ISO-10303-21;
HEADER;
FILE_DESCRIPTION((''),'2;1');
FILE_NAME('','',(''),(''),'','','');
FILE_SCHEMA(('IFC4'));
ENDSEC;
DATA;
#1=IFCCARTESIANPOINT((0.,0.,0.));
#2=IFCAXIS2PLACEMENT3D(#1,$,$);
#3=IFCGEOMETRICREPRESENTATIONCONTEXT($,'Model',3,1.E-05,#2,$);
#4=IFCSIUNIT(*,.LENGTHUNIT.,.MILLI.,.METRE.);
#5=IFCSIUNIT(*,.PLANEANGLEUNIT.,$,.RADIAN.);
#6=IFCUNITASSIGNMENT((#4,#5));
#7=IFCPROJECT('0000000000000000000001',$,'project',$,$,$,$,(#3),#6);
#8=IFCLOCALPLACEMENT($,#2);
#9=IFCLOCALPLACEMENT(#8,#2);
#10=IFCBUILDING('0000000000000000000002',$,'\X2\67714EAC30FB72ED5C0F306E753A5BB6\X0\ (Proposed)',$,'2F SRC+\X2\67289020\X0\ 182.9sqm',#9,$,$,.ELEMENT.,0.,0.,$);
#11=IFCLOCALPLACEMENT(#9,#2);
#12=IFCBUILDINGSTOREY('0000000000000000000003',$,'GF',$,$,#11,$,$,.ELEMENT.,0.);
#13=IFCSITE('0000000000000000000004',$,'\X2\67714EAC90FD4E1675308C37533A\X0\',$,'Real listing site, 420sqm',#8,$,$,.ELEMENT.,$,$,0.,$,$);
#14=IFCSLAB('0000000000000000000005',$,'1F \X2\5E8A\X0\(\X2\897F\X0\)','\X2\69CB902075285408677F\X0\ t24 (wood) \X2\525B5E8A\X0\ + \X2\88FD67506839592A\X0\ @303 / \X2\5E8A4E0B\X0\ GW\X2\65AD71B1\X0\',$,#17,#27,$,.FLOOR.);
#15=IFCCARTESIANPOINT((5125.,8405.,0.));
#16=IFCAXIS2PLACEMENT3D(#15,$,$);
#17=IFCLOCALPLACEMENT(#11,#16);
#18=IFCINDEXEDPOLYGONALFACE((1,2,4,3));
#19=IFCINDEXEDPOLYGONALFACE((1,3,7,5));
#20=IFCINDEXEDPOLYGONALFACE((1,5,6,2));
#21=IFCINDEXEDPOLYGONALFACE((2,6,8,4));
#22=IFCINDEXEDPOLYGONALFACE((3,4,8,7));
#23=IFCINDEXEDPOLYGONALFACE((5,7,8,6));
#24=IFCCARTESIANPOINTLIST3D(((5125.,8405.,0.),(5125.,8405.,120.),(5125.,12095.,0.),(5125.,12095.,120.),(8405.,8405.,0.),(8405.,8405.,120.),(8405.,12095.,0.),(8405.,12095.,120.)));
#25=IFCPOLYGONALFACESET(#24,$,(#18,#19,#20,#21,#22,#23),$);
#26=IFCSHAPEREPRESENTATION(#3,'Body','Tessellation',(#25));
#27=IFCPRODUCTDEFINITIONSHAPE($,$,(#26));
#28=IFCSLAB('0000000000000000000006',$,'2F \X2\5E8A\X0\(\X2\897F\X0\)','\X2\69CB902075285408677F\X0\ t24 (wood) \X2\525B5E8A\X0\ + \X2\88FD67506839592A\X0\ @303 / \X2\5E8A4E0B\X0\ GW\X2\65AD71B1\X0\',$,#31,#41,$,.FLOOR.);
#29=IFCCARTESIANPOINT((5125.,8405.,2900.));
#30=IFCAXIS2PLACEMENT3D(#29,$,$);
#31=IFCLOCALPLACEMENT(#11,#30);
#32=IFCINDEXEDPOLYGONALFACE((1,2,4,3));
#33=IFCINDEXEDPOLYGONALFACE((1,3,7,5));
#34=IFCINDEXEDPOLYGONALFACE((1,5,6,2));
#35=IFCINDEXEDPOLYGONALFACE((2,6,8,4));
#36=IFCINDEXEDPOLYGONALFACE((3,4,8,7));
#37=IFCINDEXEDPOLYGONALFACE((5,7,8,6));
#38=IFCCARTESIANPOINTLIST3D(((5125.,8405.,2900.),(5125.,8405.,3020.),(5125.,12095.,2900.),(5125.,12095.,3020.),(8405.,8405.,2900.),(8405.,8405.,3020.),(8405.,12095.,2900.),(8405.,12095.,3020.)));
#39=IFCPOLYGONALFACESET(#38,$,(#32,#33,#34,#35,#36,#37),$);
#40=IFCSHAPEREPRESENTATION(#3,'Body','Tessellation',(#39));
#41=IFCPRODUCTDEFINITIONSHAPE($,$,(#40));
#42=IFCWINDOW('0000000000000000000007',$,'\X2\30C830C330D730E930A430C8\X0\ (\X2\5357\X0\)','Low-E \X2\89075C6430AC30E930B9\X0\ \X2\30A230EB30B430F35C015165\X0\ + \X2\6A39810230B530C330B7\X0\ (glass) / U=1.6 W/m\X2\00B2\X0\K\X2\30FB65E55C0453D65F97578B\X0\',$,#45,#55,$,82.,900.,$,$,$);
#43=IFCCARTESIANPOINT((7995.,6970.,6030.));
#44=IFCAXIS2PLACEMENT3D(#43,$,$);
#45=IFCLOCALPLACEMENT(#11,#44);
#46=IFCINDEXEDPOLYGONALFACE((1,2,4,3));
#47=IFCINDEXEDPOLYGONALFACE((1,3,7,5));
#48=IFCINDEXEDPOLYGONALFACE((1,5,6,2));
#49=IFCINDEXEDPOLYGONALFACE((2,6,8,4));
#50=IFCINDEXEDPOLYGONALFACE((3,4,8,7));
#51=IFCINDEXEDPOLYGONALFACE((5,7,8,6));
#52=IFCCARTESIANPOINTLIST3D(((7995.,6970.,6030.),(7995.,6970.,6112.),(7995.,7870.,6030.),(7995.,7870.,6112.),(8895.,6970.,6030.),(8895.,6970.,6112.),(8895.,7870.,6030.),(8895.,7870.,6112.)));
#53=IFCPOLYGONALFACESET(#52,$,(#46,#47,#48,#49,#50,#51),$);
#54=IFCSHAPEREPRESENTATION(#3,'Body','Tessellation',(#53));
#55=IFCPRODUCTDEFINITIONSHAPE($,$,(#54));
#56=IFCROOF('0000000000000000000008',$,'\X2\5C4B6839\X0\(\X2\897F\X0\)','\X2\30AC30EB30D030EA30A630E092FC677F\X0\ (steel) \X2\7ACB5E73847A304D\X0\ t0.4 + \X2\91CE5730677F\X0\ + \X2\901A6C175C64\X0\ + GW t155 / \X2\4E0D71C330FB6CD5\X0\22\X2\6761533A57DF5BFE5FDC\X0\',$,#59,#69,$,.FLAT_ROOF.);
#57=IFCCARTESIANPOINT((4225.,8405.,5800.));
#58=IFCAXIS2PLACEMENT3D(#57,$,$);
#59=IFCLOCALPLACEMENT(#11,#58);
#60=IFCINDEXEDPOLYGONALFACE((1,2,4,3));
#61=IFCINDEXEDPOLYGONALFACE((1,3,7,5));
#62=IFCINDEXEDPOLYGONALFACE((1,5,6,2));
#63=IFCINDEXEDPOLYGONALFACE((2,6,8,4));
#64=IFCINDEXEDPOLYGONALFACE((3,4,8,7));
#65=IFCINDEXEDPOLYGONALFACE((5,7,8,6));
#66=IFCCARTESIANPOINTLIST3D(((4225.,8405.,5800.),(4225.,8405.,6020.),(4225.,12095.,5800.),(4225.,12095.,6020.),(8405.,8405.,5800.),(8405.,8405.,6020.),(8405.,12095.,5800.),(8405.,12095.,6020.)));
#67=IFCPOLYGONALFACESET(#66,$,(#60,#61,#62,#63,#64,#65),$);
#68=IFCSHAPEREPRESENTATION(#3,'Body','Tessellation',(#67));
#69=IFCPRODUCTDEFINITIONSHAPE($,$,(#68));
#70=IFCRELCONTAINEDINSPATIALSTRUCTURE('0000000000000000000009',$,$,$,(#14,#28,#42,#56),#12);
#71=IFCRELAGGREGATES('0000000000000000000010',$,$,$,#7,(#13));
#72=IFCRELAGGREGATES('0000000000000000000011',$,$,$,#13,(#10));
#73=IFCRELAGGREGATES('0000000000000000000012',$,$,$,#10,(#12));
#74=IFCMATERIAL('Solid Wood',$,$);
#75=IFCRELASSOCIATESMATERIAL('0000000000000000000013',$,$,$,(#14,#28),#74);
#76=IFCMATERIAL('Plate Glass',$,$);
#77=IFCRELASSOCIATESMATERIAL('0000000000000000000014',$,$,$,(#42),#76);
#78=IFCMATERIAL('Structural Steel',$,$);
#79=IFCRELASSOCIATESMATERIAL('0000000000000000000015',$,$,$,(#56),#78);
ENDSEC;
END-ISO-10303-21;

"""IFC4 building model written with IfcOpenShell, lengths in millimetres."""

from ifc_helpers import new_model, si_unit, frame, frame_2d, origin, place, context, project, spatial, rectangle, extrude, material, element, save


model = new_model("IFC4")

# Units and contexts
model_context = context("Model", 3, precision=1e-05, world=origin())
ifc_project = project(units=[si_unit("LENGTHUNIT", "METRE", prefix="MILLI"), si_unit("PLANEANGLEUNIT", "RADIAN")], contexts=[model_context])

# Site, building, storey
site_placement = place(None, origin())
site = spatial("IfcSite", under=ifc_project, at=site_placement, Name="東京都世田谷区", ObjectType="Real listing site, 420sqm", CompositionType="ELEMENT", RefElevation=0.0)
building_placement = place(site_placement, origin())
building = spatial("IfcBuilding", under=site, at=building_placement, Name="東京・狭小の町家 (Proposed)", ObjectType="2F SRC+木造 182.9sqm", CompositionType="ELEMENT", ElevationOfRefHeight=0.0, ElevationOfTerrain=0.0)
storey_placement = place(building_placement, origin())
storey = spatial("IfcBuildingStorey", under=building, at=storey_placement, Name="GF", CompositionType="ELEMENT", Elevation=0.0)

# Shared definitions
ifc_material_1 = material(Name="Solid Wood")

# Slabs
slab_1_placement = place(storey_placement, frame((5125.0, 8405.0, 0.0)))
element("IfcSlab", 1, at=slab_1_placement, inside=storey, material=ifc_material_1, Name="1F 床(西)", Description="構造用合板 t24 (wood) 剛床 + 製材根太 @303 / 床下 GW断熱", PredefinedType="FLOOR", context=model_context, shape_type="SweptSolid", body=[
    extrude(rectangle(XDim=3280.0, YDim=3690.0, at=frame_2d((1640.0, 1845.0))), frame((5125.0, 8405.0, 0.0)), (0.0, 0.0, 1.0), 120.0),
])
slab_2_placement = place(storey_placement, frame((5125.0, 8405.0, 2900.0)))
element("IfcSlab", 2, at=slab_2_placement, inside=storey, material=ifc_material_1, Name="2F 床(西)", Description="構造用合板 t24 (wood) 剛床 + 製材根太 @303 / 床下 GW断熱", PredefinedType="FLOOR", context=model_context, shape_type="SweptSolid", body=[
    extrude(rectangle(XDim=3280.0, YDim=3690.0, at=frame_2d((1640.0, 1845.0))), frame((5125.0, 8405.0, 2900.0)), (0.0, 0.0, 1.0), 120.0),
])

# Window
ifc_material_2 = material(Name="Plate Glass")
window_placement = place(storey_placement, frame((7995.0, 6970.0, 6030.0)))
element("IfcWindow", 3, at=window_placement, inside=storey, material=ifc_material_2, Name="トップライト (南)", Description="Low-E 複層ガラス アルゴン封入 + 樹脂サッシ (glass) / U=1.6 W/m²K・日射取得型", OverallHeight=82.0, OverallWidth=900.0, context=model_context, shape_type="SweptSolid", body=[
    extrude(rectangle(XDim=900.0, YDim=900.0, at=frame_2d((450.0, 450.0))), frame((7995.0, 6970.0, 6030.0)), (0.0, 0.0, 1.0), 82.0),
])

# Roof
ifc_material_3 = material(Name="Structural Steel")
for number, where, name in (
    (4, (4225.0, 8405.0, 5800.0), "屋根(西)"),
):
    element("IfcRoof", number, at=place(storey_placement, frame(where)), inside=storey, material=ifc_material_3, Name=name, Description="ガルバリウム鋼板 (steel) 立平葺き t0.4 + 野地板 + 通気層 + GW t155 / 不燃・法22条区域対応", PredefinedType="FLAT_ROOF", context=model_context, shape_type="SweptSolid", body=[
        extrude(rectangle(XDim=4180.0, YDim=3690.0, at=frame_2d((2090.0, 1845.0))), frame((4225.0, 8405.0, 5800.0)), (0.0, 0.0, 1.0), 220.0),
    ])

save(model, "model.ifc")
